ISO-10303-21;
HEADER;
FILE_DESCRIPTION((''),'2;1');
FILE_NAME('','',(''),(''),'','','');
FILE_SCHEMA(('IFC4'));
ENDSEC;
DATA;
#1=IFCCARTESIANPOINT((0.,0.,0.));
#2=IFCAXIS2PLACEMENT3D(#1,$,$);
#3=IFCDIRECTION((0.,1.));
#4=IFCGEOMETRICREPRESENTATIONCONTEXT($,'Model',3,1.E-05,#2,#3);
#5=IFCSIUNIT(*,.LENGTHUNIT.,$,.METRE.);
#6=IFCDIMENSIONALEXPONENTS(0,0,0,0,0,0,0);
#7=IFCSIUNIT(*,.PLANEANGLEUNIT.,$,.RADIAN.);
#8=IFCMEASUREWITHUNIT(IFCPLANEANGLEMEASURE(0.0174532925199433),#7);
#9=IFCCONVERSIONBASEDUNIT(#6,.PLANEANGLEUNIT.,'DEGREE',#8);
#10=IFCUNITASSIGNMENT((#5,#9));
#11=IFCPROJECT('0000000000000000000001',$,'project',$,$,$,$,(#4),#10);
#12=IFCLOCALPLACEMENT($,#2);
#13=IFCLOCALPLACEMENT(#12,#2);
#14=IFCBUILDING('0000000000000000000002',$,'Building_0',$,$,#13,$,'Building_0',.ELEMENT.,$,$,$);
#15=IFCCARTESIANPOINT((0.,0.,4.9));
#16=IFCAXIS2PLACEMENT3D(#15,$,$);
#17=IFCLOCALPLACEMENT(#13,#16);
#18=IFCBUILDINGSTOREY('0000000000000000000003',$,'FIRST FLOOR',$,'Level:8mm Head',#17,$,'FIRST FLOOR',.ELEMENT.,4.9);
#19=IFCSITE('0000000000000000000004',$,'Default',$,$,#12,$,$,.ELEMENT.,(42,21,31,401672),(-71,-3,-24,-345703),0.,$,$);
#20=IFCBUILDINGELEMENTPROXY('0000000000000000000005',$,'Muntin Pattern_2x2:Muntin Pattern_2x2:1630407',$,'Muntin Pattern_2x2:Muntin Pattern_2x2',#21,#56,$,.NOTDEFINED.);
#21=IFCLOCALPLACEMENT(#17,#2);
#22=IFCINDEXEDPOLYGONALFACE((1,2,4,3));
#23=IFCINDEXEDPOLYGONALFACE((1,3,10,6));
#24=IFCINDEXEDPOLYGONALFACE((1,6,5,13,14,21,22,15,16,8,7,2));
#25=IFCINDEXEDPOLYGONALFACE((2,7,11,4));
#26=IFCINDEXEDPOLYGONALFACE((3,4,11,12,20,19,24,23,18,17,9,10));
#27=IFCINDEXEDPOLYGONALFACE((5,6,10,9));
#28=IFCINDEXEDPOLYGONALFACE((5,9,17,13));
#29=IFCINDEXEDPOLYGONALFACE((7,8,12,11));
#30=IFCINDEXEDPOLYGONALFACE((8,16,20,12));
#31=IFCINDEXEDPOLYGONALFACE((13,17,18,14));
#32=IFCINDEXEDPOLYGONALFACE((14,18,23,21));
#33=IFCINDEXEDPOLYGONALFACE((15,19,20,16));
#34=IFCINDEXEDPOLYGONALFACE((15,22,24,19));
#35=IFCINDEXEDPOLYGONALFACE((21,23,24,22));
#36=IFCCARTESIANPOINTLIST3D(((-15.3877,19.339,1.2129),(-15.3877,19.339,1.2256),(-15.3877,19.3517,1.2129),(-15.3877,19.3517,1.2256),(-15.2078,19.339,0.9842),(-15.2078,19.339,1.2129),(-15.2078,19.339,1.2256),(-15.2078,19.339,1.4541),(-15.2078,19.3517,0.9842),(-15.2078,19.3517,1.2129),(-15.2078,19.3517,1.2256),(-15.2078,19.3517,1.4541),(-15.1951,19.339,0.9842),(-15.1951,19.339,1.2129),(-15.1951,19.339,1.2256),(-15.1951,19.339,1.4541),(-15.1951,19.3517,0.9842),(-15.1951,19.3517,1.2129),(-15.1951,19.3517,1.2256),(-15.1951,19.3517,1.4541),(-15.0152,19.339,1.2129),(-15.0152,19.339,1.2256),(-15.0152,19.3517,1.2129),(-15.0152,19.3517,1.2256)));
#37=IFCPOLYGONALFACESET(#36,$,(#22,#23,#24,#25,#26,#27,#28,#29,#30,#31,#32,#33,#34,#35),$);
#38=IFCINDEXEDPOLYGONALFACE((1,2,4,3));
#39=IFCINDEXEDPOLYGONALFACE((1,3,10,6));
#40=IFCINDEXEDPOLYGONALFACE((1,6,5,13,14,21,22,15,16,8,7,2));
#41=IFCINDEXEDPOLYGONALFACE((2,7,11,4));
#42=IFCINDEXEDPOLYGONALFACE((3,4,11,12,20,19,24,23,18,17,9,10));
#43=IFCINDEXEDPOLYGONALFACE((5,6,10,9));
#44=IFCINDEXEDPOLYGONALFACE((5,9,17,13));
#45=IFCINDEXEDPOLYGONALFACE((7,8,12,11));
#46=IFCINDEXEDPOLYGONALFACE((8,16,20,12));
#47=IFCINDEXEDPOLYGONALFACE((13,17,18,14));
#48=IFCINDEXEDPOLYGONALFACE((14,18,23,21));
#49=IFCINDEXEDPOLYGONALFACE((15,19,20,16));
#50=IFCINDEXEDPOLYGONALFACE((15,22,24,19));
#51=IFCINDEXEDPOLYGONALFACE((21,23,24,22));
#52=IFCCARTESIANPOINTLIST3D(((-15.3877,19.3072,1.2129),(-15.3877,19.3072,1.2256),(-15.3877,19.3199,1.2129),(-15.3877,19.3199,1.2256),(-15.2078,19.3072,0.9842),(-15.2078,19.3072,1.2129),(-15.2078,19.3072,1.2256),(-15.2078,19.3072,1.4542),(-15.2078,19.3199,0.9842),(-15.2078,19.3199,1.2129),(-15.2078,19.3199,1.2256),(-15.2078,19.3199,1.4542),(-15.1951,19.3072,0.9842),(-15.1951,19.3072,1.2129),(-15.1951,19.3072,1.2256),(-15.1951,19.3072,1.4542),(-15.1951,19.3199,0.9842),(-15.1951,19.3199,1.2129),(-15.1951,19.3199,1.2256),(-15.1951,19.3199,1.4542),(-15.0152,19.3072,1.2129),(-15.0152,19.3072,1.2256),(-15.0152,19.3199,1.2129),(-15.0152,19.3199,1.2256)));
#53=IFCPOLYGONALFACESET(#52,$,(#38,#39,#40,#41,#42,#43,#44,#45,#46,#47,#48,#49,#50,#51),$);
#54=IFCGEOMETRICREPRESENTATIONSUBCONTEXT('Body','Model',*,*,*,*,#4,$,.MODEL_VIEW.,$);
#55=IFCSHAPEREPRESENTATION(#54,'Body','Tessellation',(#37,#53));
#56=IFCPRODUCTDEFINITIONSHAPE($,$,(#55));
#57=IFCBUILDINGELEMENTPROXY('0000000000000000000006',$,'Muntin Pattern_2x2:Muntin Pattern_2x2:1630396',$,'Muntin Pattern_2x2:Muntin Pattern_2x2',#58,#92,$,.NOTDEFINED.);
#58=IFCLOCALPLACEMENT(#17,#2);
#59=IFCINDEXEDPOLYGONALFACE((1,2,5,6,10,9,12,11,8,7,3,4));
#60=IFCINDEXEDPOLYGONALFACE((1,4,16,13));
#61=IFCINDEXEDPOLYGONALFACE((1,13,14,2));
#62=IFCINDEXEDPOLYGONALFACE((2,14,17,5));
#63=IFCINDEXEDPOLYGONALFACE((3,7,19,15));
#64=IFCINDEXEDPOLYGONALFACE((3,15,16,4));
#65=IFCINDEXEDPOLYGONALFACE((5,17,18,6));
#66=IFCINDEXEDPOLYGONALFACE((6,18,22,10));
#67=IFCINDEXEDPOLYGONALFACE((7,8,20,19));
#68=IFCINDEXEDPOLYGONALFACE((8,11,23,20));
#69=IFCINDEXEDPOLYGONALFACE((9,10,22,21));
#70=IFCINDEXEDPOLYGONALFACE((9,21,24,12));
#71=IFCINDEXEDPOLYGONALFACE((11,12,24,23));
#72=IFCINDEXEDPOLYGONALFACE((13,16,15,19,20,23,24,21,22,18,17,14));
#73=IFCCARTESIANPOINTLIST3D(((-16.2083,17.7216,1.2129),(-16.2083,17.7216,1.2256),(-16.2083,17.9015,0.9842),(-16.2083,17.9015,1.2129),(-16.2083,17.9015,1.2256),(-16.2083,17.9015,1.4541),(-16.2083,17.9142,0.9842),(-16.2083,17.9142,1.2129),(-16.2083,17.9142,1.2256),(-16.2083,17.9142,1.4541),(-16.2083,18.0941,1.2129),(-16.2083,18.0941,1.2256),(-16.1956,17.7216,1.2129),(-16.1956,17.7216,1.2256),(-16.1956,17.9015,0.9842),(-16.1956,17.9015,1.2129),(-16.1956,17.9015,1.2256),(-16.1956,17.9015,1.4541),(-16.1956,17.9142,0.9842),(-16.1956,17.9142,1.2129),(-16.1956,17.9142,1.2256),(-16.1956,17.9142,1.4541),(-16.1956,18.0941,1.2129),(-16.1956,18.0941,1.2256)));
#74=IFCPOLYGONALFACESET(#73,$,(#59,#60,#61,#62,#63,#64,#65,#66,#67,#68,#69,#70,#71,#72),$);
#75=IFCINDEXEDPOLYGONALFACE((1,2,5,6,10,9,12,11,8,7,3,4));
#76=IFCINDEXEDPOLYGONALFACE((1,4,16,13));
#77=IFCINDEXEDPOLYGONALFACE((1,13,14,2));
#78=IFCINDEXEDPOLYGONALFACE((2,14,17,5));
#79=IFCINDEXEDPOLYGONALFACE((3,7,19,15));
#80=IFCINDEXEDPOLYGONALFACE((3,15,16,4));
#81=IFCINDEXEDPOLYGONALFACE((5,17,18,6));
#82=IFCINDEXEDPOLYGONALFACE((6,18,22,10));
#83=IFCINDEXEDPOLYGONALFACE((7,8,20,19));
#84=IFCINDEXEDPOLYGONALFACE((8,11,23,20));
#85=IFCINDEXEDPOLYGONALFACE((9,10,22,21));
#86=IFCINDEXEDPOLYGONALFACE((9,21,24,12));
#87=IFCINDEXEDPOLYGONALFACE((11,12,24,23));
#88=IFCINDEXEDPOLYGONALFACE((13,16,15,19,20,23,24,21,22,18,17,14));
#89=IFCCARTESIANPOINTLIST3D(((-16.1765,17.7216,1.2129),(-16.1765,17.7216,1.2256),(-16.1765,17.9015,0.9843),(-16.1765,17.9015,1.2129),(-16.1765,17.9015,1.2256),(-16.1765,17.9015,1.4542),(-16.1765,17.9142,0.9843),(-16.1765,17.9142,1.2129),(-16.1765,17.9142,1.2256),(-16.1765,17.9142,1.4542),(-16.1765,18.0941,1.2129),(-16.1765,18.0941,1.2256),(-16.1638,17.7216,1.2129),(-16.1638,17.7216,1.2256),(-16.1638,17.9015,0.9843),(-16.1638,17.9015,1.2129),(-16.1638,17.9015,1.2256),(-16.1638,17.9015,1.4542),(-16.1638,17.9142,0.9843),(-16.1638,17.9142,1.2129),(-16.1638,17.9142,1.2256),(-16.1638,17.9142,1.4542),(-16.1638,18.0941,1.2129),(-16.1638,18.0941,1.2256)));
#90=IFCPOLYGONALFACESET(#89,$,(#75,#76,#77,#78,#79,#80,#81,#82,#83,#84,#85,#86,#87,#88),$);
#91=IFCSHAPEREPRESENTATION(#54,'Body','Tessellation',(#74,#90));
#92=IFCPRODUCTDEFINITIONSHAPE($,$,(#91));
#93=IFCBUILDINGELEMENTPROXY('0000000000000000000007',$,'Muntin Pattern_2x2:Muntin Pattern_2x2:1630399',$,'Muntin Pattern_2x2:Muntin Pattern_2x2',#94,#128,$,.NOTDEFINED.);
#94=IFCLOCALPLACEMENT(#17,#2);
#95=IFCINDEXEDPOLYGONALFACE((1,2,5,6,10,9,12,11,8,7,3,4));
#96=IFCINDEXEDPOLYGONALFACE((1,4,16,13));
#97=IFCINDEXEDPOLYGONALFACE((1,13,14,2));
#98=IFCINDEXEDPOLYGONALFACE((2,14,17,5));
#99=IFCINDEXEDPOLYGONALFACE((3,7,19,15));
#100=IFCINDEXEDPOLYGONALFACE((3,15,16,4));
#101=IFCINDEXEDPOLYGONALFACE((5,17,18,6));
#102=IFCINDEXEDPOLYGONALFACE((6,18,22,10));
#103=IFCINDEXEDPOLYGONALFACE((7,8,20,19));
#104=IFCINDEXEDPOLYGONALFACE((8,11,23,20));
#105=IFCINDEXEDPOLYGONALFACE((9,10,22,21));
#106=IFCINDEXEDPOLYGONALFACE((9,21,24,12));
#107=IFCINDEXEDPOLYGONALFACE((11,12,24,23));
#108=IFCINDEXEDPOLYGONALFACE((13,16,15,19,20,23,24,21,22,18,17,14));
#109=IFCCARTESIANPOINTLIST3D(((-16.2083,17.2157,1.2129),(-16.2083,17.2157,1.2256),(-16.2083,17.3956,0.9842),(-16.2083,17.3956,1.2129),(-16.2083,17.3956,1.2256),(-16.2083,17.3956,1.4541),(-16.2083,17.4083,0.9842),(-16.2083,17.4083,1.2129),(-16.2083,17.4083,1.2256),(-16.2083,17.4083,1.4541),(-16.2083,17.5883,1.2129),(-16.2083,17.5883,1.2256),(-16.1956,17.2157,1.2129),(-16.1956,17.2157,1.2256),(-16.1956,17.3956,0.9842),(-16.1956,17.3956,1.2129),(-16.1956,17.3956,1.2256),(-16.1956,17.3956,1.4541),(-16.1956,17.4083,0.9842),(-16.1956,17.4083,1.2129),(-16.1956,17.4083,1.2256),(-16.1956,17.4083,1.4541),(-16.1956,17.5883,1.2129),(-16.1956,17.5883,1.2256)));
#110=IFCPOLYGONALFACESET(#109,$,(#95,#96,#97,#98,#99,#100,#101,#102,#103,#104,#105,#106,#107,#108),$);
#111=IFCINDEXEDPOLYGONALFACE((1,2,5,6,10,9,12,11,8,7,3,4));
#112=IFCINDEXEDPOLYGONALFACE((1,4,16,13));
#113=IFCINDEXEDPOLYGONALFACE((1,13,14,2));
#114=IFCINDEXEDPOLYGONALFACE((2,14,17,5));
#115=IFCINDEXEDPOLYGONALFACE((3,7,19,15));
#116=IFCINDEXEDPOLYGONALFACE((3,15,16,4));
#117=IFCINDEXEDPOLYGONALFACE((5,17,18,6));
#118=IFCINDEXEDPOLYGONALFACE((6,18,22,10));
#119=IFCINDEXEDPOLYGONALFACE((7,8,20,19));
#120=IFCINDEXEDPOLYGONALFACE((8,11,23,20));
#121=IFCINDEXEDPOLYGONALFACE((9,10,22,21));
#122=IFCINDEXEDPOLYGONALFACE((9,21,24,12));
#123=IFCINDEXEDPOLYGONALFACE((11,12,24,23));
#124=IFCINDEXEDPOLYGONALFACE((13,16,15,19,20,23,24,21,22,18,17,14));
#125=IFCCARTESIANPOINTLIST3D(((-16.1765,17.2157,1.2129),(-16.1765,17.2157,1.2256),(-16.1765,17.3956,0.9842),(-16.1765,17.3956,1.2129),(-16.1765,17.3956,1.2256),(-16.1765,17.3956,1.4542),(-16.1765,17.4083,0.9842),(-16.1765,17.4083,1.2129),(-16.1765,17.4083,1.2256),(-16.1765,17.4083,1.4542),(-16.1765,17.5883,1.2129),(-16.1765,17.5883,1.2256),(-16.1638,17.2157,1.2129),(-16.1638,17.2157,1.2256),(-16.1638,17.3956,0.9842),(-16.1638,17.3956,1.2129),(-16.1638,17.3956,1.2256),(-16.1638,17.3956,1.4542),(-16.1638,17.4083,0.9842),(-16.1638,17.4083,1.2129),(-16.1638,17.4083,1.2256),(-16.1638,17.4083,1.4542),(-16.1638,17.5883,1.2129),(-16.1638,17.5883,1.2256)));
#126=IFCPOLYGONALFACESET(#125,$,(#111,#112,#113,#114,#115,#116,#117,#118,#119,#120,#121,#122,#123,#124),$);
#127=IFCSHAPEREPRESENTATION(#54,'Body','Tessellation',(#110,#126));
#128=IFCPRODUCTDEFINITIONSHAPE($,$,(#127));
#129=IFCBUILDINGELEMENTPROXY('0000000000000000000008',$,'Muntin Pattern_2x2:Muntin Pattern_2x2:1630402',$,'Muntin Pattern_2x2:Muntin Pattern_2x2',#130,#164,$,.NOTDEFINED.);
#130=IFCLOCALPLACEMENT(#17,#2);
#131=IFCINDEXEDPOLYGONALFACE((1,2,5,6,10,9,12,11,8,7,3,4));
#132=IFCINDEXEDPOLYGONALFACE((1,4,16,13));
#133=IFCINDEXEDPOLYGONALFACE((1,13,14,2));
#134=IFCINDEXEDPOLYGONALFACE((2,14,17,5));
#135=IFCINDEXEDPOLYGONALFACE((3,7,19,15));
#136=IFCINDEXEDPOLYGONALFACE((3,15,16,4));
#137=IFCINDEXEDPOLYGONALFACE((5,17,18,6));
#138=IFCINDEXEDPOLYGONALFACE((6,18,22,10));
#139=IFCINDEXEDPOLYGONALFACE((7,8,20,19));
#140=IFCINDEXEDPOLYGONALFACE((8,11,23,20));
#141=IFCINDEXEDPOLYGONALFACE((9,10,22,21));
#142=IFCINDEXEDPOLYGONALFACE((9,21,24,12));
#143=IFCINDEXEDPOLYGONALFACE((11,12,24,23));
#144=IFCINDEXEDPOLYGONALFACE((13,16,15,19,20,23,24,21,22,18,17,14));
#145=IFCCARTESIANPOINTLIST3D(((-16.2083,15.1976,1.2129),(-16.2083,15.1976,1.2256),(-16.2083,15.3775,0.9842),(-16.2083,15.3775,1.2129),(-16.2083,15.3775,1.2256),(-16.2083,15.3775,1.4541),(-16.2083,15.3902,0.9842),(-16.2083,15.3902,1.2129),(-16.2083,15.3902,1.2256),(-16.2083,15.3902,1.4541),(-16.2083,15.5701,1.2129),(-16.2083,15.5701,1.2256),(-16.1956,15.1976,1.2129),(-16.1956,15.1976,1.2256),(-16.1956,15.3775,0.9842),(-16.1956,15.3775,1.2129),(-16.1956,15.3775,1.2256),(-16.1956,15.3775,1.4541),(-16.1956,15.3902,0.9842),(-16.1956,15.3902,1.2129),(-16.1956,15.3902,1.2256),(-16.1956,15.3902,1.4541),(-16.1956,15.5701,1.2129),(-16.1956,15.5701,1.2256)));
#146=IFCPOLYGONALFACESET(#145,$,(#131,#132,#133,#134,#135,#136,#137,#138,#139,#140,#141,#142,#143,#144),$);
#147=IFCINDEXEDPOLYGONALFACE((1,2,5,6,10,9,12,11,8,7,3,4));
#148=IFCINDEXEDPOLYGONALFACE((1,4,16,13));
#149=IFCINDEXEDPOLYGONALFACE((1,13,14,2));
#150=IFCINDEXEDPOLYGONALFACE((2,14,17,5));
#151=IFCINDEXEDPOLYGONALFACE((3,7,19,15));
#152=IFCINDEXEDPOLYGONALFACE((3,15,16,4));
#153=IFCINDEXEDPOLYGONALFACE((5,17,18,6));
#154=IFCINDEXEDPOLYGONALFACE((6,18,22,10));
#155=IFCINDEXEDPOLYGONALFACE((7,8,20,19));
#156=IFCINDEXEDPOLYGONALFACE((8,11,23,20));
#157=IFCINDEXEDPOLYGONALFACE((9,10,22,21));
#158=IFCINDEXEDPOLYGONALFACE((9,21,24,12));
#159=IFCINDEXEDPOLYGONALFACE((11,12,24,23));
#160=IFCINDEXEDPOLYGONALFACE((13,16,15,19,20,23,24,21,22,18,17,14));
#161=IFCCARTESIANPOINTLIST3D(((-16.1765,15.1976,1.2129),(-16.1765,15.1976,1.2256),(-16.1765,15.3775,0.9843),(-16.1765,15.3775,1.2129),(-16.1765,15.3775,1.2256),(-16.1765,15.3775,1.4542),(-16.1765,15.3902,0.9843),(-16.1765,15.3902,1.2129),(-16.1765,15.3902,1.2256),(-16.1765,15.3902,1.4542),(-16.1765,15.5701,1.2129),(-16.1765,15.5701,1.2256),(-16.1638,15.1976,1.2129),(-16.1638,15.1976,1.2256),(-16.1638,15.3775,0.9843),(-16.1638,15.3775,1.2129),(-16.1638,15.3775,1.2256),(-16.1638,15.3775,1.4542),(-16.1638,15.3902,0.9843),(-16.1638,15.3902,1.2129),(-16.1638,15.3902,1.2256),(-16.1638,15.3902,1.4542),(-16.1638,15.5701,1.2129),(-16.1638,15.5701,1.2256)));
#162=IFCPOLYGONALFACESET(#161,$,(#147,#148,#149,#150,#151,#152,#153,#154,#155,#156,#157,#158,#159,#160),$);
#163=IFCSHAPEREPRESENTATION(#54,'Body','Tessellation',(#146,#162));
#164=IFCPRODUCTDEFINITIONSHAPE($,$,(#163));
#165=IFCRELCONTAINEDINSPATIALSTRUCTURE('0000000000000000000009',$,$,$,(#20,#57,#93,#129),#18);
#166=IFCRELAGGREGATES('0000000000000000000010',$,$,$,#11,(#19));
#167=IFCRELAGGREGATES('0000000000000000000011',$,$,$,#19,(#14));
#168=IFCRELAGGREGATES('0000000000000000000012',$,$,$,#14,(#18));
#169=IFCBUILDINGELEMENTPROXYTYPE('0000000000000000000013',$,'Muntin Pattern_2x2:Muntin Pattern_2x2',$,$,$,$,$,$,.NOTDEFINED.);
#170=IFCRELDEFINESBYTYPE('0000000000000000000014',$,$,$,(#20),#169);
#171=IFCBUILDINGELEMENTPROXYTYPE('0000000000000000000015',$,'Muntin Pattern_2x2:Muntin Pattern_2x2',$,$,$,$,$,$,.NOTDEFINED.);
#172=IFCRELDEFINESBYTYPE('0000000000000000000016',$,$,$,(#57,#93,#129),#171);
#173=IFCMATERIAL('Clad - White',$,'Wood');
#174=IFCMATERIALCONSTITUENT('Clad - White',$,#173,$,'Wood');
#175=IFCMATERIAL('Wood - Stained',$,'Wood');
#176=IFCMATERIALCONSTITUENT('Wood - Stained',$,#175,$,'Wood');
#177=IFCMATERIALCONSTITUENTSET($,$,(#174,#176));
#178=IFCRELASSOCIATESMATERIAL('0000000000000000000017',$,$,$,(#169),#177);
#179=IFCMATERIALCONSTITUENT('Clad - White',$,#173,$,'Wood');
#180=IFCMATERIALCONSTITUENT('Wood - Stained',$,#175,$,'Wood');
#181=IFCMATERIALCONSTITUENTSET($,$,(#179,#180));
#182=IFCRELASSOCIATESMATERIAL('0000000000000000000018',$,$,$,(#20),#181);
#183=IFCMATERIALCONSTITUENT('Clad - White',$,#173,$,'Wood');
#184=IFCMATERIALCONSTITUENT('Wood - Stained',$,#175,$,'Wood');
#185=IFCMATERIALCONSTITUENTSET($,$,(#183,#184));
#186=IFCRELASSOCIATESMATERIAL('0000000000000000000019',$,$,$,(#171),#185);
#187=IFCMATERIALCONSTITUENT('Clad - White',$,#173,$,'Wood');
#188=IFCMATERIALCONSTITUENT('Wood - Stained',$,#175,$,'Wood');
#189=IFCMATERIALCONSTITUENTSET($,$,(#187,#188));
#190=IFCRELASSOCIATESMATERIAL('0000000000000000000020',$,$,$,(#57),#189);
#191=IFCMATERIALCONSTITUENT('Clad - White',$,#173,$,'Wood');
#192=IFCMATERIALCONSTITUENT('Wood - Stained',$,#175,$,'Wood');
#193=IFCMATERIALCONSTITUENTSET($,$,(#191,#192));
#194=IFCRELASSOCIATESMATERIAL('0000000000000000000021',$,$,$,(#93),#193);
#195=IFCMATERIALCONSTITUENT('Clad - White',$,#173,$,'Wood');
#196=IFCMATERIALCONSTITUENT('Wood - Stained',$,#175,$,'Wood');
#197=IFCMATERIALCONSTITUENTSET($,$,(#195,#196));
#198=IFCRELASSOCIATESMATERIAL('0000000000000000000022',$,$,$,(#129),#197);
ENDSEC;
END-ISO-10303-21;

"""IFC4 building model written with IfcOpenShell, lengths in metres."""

from ifc_helpers import new_model, entity, si_unit, converted_unit, direction, frame, origin, place, context, subcontext, project, spatial, indexed_curve, outline, extrude, source, transform, mapped, material, constituent, constituent_set, type_object, type_shapes, element, save


model = new_model("IFC4")

# Units and contexts
model_context = context("Model", 3, precision=1e-05, world=origin(), true_north=direction((0.0, 1.0)))
body_context = subcontext(model_context, "Body", "Model", "MODEL_VIEW")
ifc_project = project(units=[si_unit("LENGTHUNIT", "METRE"), converted_unit("PLANEANGLEUNIT", "DEGREE", entity("IfcPlaneAngleMeasure", 0.0174532925199433), si_unit("PLANEANGLEUNIT", "RADIAN"), dimensions=[0, 0, 0, 0, 0, 0, 0])], contexts=[model_context])

# Site, building, storey
site_placement = place(None, origin())
site = spatial("IfcSite", under=ifc_project, at=site_placement, Name="Default", CompositionType="ELEMENT", RefLatitude=(42, 21, 31, 401672), RefLongitude=(-71, -3, -24, -345703), RefElevation=0.0)
building_placement = place(site_placement, origin())
building = spatial("IfcBuilding", under=site, at=building_placement, Name="Building_0", LongName="Building_0", CompositionType="ELEMENT")
storey_placement = place(building_placement, frame((0.0, 0.0, 4.9)))
storey = spatial("IfcBuildingStorey", under=building, at=storey_placement, Name="FIRST FLOOR", ObjectType="Level:8mm Head", LongName="FIRST FLOOR", CompositionType="ELEMENT", Elevation=4.9)

# Shared definitions
ifc_material_1 = material(Name="Clad - White", Category="Wood")

# Building element proxies
ifc_material_2 = material(Name="Wood - Stained", Category="Wood")
ifc_constituent_1 = constituent(ifc_material_1, Name="Clad - White", Category="Wood")
ifc_constituent_2 = constituent(ifc_material_2, Name="Wood - Stained", Category="Wood")
ifc_constituent_set_1 = constituent_set(constituents=[ifc_constituent_1, ifc_constituent_2])
building_element_proxy_type_1 = type_object("IfcBuildingElementProxyType", Name="Muntin Pattern_2x2:Muntin Pattern_2x2", PredefinedType="NOTDEFINED", material=ifc_constituent_set_1)
shared_shape_1 = source(origin(), body_context, "Body", "SweptSolid", [
    extrude(outline(indexed_curve([(0.0064, -0.0064), (0.2349, -0.0064), (0.2349, 0.0063), (0.0064, 0.0063), (0.0064, 0.1863), (-0.0063, 0.1863), (-0.0063, 0.0063), (-0.235, 0.0063), (-0.235, -0.0064), (-0.0063, -0.0064), (-0.0063, -0.1863), (0.0064, -0.1863), (0.0064, -0.0064)], self_intersect=False)), frame((0.0, 0.0095, 0.235), z_axis=(0.0, 1.0, 0.0), x_axis=(0.0, 0.0, 1.0)), (0.0, 0.0, 1.0), 0.0127),
    extrude(outline(indexed_curve([(0.0064, -0.0064), (0.235, -0.0064), (0.235, 0.0063), (0.0064, 0.0063), (0.0064, 0.1863), (-0.0063, 0.1863), (-0.0063, 0.0063), (-0.235, 0.0063), (-0.235, -0.0064), (-0.0063, -0.0064), (-0.0063, -0.1863), (0.0064, -0.1863), (0.0064, -0.0064)], self_intersect=False)), frame((0.0, -0.0222, 0.235), z_axis=(0.0, 1.0, 0.0), x_axis=(0.0, 0.0, 1.0)), (0.0, 0.0, 1.0), 0.0127),
])
type_shapes(building_element_proxy_type_1, [shared_shape_1])
ifc_constituent_3 = constituent(ifc_material_1, Name="Clad - White", Category="Wood")
ifc_constituent_4 = constituent(ifc_material_2, Name="Wood - Stained", Category="Wood")
ifc_constituent_set_2 = constituent_set(constituents=[ifc_constituent_3, ifc_constituent_4])
proxy_1_placement = place(storey_placement, frame((-15.2015, 19.3295, 0.9842)))
element("IfcBuildingElementProxy", 1, at=proxy_1_placement, inside=storey, type_object=building_element_proxy_type_1, material=ifc_constituent_set_2, Name="Muntin Pattern_2x2:Muntin Pattern_2x2:1630407", ObjectType="Muntin Pattern_2x2:Muntin Pattern_2x2", PredefinedType="NOTDEFINED", context=body_context, shape_type="MappedRepresentation", body=[
    mapped(shared_shape_1, transform((0.0, 0.0, 0.0), scale=1.0)),
])
ifc_constituent_5 = constituent(ifc_material_1, Name="Clad - White", Category="Wood")
ifc_constituent_6 = constituent(ifc_material_2, Name="Wood - Stained", Category="Wood")
ifc_constituent_set_3 = constituent_set(constituents=[ifc_constituent_5, ifc_constituent_6])
ifc_constituent_7 = constituent(ifc_material_1, Name="Clad - White", Category="Wood")
ifc_constituent_8 = constituent(ifc_material_2, Name="Wood - Stained", Category="Wood")
ifc_constituent_set_4 = constituent_set(constituents=[ifc_constituent_7, ifc_constituent_8])
building_element_proxy_type_2 = type_object("IfcBuildingElementProxyType", Name="Muntin Pattern_2x2:Muntin Pattern_2x2", PredefinedType="NOTDEFINED", material=ifc_constituent_set_4)
shared_shape_2 = source(origin(), body_context, "Body", "SweptSolid", [
    extrude(outline(indexed_curve([(0.0064, -0.0064), (0.2349, -0.0064), (0.2349, 0.0063), (0.0064, 0.0063), (0.0064, 0.1863), (-0.0063, 0.1863), (-0.0063, 0.0063), (-0.235, 0.0063), (-0.235, -0.0064), (-0.0063, -0.0064), (-0.0063, -0.1863), (0.0064, -0.1863), (0.0064, -0.0064)], self_intersect=False)), frame((0.0, -0.0222, 0.2349), z_axis=(0.0, 1.0, 0.0), x_axis=(0.0, 0.0, 1.0)), (0.0, 0.0, 1.0), 0.0127),
    extrude(outline(indexed_curve([(0.0064, -0.0064), (0.235, -0.0064), (0.235, 0.0063), (0.0064, 0.0063), (0.0064, 0.1863), (-0.0063, 0.1863), (-0.0063, 0.0063), (-0.235, 0.0063), (-0.235, -0.0064), (-0.0063, -0.0064), (-0.0063, -0.1863), (0.0064, -0.1863), (0.0064, -0.0064)], self_intersect=False)), frame((0.0, 0.0095, 0.235), z_axis=(0.0, 1.0, 0.0), x_axis=(0.0, 0.0, 1.0)), (0.0, 0.0, 1.0), 0.0127),
])
type_shapes(building_element_proxy_type_2, [shared_shape_2])
proxy_2_placement = place(storey_placement, frame((-16.1861, 17.9079, 0.9843), z_axis=(0.0, 0.0, 1.0), x_axis=(0.0, -1.0, 0.0)))
element("IfcBuildingElementProxy", 2, at=proxy_2_placement, inside=storey, type_object=building_element_proxy_type_2, material=ifc_constituent_set_3, Name="Muntin Pattern_2x2:Muntin Pattern_2x2:1630396", ObjectType="Muntin Pattern_2x2:Muntin Pattern_2x2", PredefinedType="NOTDEFINED", context=body_context, shape_type="MappedRepresentation", body=[
    mapped(shared_shape_2, transform((0.0, 0.0, 0.0), scale=1.0)),
])
ifc_constituent_9 = constituent(ifc_material_1, Name="Clad - White", Category="Wood")
ifc_constituent_10 = constituent(ifc_material_2, Name="Wood - Stained", Category="Wood")
ifc_constituent_set_5 = constituent_set(constituents=[ifc_constituent_9, ifc_constituent_10])
proxy_3_placement = place(storey_placement, frame((-16.1861, 17.402, 0.9842), z_axis=(0.0, 0.0, 1.0), x_axis=(0.0, -1.0, 0.0)))
element("IfcBuildingElementProxy", 3, at=proxy_3_placement, inside=storey, type_object=building_element_proxy_type_2, material=ifc_constituent_set_5, Name="Muntin Pattern_2x2:Muntin Pattern_2x2:1630399", ObjectType="Muntin Pattern_2x2:Muntin Pattern_2x2", PredefinedType="NOTDEFINED", context=body_context, shape_type="MappedRepresentation", body=[
    mapped(shared_shape_2, transform((0.0, 0.0, 0.0), scale=1.0)),
])
ifc_constituent_11 = constituent(ifc_material_1, Name="Clad - White", Category="Wood")
ifc_constituent_12 = constituent(ifc_material_2, Name="Wood - Stained", Category="Wood")
ifc_constituent_set_6 = constituent_set(constituents=[ifc_constituent_11, ifc_constituent_12])
proxy_4_placement = place(storey_placement, frame((-16.1861, 15.3839, 0.9843), z_axis=(0.0, 0.0, 1.0), x_axis=(0.0, -1.0, 0.0)))
element("IfcBuildingElementProxy", 4, at=proxy_4_placement, inside=storey, type_object=building_element_proxy_type_2, material=ifc_constituent_set_6, Name="Muntin Pattern_2x2:Muntin Pattern_2x2:1630402", ObjectType="Muntin Pattern_2x2:Muntin Pattern_2x2", PredefinedType="NOTDEFINED", context=body_context, shape_type="MappedRepresentation", body=[
    mapped(shared_shape_2, transform((0.0, 0.0, 0.0), scale=1.0)),
])

save(model, "model.ifc")
